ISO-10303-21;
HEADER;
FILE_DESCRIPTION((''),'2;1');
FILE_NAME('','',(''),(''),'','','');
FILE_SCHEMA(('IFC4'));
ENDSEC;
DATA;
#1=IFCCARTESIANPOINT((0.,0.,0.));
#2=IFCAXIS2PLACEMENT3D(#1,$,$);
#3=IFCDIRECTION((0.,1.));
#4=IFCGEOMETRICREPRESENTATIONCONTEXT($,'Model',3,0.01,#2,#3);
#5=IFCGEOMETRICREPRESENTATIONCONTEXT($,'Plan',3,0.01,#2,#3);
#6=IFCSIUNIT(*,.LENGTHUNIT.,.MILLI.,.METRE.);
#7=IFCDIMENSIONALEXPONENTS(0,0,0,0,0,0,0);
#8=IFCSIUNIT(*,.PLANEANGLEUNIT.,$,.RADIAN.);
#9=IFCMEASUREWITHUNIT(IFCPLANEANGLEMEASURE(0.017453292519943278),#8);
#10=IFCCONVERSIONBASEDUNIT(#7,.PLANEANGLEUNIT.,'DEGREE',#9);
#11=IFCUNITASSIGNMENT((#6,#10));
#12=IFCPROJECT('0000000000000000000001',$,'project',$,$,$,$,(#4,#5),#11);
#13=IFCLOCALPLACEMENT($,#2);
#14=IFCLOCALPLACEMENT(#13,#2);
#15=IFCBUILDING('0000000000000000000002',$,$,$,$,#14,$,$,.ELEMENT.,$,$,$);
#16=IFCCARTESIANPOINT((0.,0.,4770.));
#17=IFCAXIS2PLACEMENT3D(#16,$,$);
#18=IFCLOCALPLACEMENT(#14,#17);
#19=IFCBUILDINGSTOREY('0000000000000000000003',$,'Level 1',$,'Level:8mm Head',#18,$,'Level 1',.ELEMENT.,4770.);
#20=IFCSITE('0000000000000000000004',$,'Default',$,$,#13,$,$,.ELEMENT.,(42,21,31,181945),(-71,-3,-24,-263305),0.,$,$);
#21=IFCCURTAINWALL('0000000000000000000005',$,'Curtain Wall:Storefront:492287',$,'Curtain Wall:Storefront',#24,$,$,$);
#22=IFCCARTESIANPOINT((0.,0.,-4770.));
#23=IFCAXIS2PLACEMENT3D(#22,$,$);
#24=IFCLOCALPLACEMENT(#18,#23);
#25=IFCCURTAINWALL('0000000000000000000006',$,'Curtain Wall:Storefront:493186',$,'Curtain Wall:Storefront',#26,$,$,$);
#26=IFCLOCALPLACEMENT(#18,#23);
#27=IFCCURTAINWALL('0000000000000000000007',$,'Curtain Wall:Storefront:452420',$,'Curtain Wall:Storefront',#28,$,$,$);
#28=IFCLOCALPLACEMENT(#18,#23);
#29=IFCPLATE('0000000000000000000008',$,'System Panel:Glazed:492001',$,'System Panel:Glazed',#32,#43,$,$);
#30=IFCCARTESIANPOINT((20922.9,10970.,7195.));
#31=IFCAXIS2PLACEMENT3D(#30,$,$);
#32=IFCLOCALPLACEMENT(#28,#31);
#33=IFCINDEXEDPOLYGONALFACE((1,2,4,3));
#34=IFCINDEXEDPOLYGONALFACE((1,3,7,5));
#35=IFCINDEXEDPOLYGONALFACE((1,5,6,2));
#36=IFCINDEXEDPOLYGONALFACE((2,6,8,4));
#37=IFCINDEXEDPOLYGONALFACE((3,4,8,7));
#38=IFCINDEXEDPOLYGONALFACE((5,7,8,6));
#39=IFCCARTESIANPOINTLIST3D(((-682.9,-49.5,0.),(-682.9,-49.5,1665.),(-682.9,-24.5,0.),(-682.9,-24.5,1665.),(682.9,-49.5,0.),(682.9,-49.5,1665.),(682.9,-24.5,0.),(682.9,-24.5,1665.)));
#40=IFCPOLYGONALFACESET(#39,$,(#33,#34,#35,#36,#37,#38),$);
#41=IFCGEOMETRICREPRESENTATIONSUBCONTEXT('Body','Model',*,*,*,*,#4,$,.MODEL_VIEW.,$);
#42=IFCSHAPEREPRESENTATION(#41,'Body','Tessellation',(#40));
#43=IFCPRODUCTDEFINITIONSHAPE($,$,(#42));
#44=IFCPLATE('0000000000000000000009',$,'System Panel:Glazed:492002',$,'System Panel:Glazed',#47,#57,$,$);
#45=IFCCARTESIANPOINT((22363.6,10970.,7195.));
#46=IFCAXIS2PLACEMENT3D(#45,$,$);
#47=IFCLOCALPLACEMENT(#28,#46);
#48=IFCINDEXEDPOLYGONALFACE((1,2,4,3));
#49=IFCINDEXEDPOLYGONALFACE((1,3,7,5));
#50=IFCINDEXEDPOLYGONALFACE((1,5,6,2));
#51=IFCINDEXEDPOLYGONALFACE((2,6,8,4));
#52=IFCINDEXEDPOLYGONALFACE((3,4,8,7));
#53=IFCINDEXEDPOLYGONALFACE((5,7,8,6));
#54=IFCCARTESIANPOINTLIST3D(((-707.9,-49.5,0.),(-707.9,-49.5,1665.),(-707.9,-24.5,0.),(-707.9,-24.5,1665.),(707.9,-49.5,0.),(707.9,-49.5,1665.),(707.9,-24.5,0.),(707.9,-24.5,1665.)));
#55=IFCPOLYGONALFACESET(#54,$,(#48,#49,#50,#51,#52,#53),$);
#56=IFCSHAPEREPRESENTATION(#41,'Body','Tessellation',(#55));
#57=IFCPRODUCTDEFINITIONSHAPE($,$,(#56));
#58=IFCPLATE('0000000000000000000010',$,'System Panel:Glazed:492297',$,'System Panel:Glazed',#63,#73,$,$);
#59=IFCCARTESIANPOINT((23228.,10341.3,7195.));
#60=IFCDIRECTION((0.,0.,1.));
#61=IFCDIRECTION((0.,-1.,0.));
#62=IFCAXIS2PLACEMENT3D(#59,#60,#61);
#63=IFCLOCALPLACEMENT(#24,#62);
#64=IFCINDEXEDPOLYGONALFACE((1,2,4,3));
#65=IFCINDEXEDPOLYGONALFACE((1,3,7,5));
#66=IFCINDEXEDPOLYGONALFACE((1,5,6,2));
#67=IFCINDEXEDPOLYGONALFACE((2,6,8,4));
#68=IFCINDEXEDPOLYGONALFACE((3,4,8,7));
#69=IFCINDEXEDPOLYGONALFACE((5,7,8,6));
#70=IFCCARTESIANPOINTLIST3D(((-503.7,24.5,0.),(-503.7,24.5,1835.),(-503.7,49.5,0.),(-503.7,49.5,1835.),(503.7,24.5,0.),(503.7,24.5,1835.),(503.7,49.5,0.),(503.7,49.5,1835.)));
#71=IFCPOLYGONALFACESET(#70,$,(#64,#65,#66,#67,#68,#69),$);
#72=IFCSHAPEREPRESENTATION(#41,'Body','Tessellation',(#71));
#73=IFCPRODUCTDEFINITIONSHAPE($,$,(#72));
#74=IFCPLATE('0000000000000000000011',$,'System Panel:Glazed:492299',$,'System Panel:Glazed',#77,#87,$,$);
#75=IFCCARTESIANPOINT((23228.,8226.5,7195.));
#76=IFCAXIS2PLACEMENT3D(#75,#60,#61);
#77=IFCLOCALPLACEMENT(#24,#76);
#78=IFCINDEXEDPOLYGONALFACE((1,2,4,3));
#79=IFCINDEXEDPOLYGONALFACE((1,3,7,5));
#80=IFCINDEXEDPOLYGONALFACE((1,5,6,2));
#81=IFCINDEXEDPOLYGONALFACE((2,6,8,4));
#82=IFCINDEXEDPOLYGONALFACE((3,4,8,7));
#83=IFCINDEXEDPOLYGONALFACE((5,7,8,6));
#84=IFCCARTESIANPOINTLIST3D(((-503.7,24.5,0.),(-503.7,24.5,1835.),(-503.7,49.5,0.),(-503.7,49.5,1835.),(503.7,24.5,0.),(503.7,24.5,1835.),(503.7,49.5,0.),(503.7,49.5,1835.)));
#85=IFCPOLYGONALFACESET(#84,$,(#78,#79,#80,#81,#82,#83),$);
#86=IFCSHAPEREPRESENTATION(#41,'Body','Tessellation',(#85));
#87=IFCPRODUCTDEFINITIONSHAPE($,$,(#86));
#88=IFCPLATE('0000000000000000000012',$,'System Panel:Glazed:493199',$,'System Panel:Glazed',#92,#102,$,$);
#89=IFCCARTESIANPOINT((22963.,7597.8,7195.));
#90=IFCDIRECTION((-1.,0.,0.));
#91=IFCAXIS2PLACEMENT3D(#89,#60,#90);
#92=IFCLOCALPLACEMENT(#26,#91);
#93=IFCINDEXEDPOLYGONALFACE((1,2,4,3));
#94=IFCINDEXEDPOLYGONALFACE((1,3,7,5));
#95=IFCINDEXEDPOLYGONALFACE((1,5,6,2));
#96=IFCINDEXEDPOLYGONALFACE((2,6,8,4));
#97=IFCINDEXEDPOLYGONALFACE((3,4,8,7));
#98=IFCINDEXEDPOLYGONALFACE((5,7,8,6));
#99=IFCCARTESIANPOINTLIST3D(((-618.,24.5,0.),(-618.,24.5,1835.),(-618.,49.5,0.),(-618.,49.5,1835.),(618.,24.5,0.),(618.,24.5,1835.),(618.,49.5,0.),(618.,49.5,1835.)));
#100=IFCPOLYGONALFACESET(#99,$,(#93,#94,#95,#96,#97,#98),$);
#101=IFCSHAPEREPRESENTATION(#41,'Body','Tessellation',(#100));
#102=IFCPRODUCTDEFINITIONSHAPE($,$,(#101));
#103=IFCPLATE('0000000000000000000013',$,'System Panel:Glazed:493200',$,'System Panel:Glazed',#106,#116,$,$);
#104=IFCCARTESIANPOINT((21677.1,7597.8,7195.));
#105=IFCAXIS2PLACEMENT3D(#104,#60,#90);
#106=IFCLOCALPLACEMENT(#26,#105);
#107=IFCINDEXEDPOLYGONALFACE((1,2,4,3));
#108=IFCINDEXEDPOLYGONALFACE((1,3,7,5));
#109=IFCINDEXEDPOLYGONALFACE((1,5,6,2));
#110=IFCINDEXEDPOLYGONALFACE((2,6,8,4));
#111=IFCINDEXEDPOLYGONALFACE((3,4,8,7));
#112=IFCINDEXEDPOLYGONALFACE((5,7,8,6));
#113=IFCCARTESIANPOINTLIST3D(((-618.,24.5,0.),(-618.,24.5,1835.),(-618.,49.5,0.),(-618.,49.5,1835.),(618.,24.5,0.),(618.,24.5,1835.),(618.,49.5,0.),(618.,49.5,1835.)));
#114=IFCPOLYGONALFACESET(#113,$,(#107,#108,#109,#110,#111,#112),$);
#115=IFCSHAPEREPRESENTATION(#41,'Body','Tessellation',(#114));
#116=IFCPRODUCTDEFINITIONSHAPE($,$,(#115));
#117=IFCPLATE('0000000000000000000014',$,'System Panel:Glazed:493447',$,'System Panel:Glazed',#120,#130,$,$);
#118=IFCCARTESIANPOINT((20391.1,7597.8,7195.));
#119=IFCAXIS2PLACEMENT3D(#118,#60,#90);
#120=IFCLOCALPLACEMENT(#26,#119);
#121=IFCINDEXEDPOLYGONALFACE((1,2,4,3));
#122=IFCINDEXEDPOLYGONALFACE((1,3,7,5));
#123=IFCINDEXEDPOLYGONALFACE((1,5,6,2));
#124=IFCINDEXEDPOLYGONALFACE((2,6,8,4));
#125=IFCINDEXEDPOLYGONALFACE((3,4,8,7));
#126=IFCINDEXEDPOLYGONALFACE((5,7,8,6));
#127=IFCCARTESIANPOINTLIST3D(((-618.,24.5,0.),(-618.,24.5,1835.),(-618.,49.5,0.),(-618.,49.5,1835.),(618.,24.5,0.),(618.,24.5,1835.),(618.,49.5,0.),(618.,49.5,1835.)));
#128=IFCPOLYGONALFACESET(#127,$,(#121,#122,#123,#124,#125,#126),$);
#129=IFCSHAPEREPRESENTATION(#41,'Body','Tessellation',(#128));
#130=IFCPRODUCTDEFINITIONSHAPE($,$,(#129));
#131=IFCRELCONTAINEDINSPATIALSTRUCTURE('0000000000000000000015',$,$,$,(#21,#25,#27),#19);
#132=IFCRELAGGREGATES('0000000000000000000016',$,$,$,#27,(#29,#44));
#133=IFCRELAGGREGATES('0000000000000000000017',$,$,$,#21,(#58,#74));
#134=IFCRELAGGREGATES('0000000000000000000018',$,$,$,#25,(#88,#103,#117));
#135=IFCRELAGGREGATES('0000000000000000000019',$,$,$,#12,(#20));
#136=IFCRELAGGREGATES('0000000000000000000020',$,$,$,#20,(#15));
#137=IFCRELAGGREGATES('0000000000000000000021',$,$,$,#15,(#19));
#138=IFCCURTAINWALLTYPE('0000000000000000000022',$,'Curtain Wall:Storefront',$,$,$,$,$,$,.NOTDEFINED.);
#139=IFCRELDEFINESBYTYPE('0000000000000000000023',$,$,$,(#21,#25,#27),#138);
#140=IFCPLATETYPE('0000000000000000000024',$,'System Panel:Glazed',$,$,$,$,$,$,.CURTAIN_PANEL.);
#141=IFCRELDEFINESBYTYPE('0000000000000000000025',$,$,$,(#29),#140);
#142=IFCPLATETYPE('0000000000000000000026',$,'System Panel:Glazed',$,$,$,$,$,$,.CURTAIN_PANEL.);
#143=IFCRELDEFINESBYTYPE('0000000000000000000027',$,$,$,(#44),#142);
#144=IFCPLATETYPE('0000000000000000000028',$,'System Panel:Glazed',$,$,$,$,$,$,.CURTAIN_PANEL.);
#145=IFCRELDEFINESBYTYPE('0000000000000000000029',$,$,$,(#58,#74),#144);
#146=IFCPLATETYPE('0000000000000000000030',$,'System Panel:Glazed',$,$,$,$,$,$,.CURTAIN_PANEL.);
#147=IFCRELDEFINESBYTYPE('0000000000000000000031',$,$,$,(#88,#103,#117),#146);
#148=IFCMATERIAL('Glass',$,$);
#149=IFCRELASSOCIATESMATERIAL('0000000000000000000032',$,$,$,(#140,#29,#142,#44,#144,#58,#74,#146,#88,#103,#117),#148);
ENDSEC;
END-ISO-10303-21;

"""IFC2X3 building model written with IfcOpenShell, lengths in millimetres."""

from ifc_helpers import new_model, entity, si_unit, converted_unit, direction, frame, frame_2d, origin, origin_2d_with_axis, place, context, subcontext, project, spatial, rectangle, extrude, source, transform, mapped, material, type_object, type_shapes, element, aggregate, save


model = new_model("IFC2X3")

# Units and contexts
model_context = context("Model", 3, precision=0.01, world=origin(), true_north=direction((0.0, 1.0)))
plan_context = context("Plan", 3, precision=0.01, world=origin(), true_north=direction((0.0, 1.0)))
body_context = subcontext(model_context, "Body", "Model", "MODEL_VIEW")
ifc_project = project(units=[si_unit("LENGTHUNIT", "METRE", prefix="MILLI"), converted_unit("PLANEANGLEUNIT", "DEGREE", entity("IfcPlaneAngleMeasure", 0.017453292519943278), si_unit("PLANEANGLEUNIT", "RADIAN"), dimensions=[0, 0, 0, 0, 0, 0, 0])], contexts=[model_context, plan_context])

# Site, building, storey
site_placement = place(None, origin())
site = spatial("IfcSite", under=ifc_project, at=site_placement, Name="Default", CompositionType="ELEMENT", RefLatitude=(42, 21, 31, 181945), RefLongitude=(-71, -3, -24, -263305), RefElevation=0.0)
building_placement = place(site_placement, origin())
building = spatial("IfcBuilding", under=site, at=building_placement, CompositionType="ELEMENT")
storey_placement = place(building_placement, frame((0.0, 0.0, 4770.0)))
storey = spatial("IfcBuildingStorey", under=building, at=storey_placement, Name="Level 1", ObjectType="Level:8mm Head", LongName="Level 1", CompositionType="ELEMENT", Elevation=4770.0)

# Curtain wall
curtain_wall_type = type_object("IfcCurtainWallType", Name="Curtain Wall:Storefront", PredefinedType="NOTDEFINED")
curtain_wall_1_placement = place(storey_placement, frame((0.0, 0.0, -4770.0)))
curtain_wall_1 = element("IfcCurtainWall", 1, at=curtain_wall_1_placement, inside=storey, type_object=curtain_wall_type, Name="Curtain Wall:Storefront:492287", ObjectType="Curtain Wall:Storefront")

# Curtain wall
curtain_wall_2_placement = place(storey_placement, frame((0.0, 0.0, -4770.0)))
curtain_wall_2 = element("IfcCurtainWall", 2, at=curtain_wall_2_placement, inside=storey, type_object=curtain_wall_type, Name="Curtain Wall:Storefront:493186", ObjectType="Curtain Wall:Storefront")

# Curtain wall
curtain_wall_3_placement = place(storey_placement, frame((0.0, 0.0, -4770.0)))
curtain_wall_3 = element("IfcCurtainWall", 3, at=curtain_wall_3_placement, inside=storey, type_object=curtain_wall_type, Name="Curtain Wall:Storefront:452420", ObjectType="Curtain Wall:Storefront")

# Plates
ifc_material_1 = material(Name="Glass")
plate_type_1 = type_object("IfcPlateType", Name="System Panel:Glazed", PredefinedType="CURTAIN_PANEL", material=ifc_material_1)
shared_shape_1 = source(origin(), body_context, "Body", "SweptSolid", [
    extrude(rectangle(XDim=25.0, YDim=1365.7, at=frame_2d((0.0, 0.0), x_axis=(1.0, 0.0))), frame((0.0, -37.0, 0.0), z_axis=(0.0, 0.0, 1.0), x_axis=(0.0, 1.0, 0.0)), (0.0, 0.0, 1.0), 1665.0),
])
type_shapes(plate_type_1, [shared_shape_1])
plate_1_placement = place(curtain_wall_3_placement, frame((20922.9, 10970.0, 7195.0)))
plate_1 = element("IfcPlate", 4, at=plate_1_placement, type_object=plate_type_1, material=ifc_material_1, Name="System Panel:Glazed:492001", ObjectType="System Panel:Glazed", context=body_context, shape_type="MappedRepresentation", body=[
    mapped(shared_shape_1, transform((0.0, 0.0, 0.0), scale=1.0)),
])
plate_type_2 = type_object("IfcPlateType", Name="System Panel:Glazed", PredefinedType="CURTAIN_PANEL", material=ifc_material_1)
shared_shape_2 = source(origin(), body_context, "Body", "SweptSolid", [
    extrude(rectangle(XDim=25.0, YDim=1415.7, at=frame_2d((0.0, 0.0), x_axis=(1.0, 0.0))), frame((0.0, -37.0, 0.0), z_axis=(0.0, 0.0, 1.0), x_axis=(0.0, 1.0, 0.0)), (0.0, 0.0, 1.0), 1665.0),
])
type_shapes(plate_type_2, [shared_shape_2])
plate_2_placement = place(curtain_wall_3_placement, frame((22363.6, 10970.0, 7195.0)))
plate_2 = element("IfcPlate", 5, at=plate_2_placement, type_object=plate_type_2, material=ifc_material_1, Name="System Panel:Glazed:492002", ObjectType="System Panel:Glazed", context=body_context, shape_type="MappedRepresentation", body=[
    mapped(shared_shape_2, transform((0.0, 0.0, 0.0), scale=1.0)),
])
aggregate(curtain_wall_3, [plate_1, plate_2])
plate_type_3 = type_object("IfcPlateType", Name="System Panel:Glazed", PredefinedType="CURTAIN_PANEL", material=ifc_material_1)
shared_shape_3 = source(origin(), body_context, "Body", "SweptSolid", [
    extrude(rectangle(XDim=25.0, YDim=1007.4, at=origin_2d_with_axis()), frame((0.0, 37.0, 0.0), z_axis=(0.0, 0.0, 1.0), x_axis=(0.0, 1.0, 0.0)), (0.0, 0.0, 1.0), 1835.0),
])
type_shapes(plate_type_3, [shared_shape_3])
plate_3_placement = place(curtain_wall_1_placement, frame((23228.0, 10341.3, 7195.0), z_axis=(0.0, 0.0, 1.0), x_axis=(0.0, -1.0, 0.0)))
plate_3 = element("IfcPlate", 6, at=plate_3_placement, type_object=plate_type_3, material=ifc_material_1, Name="System Panel:Glazed:492297", ObjectType="System Panel:Glazed", context=body_context, shape_type="MappedRepresentation", body=[
    mapped(shared_shape_3, transform((0.0, 0.0, 0.0), scale=1.0)),
])
plate_4_placement = place(curtain_wall_1_placement, frame((23228.0, 8226.5, 7195.0), z_axis=(0.0, 0.0, 1.0), x_axis=(0.0, -1.0, 0.0)))
plate_4 = element("IfcPlate", 7, at=plate_4_placement, type_object=plate_type_3, material=ifc_material_1, Name="System Panel:Glazed:492299", ObjectType="System Panel:Glazed", context=body_context, shape_type="MappedRepresentation", body=[
    mapped(shared_shape_3, transform((0.0, 0.0, 0.0), scale=1.0)),
])
aggregate(curtain_wall_1, [plate_3, plate_4])
plate_type_4 = type_object("IfcPlateType", Name="System Panel:Glazed", PredefinedType="CURTAIN_PANEL", material=ifc_material_1)
shared_shape_4 = source(origin(), body_context, "Body", "SweptSolid", [
    extrude(rectangle(XDim=25.0, YDim=1236.0, at=origin_2d_with_axis()), frame((0.0, 37.0, 0.0), z_axis=(0.0, 0.0, 1.0), x_axis=(0.0, 1.0, 0.0)), (0.0, 0.0, 1.0), 1835.0),
])
type_shapes(plate_type_4, [shared_shape_4])
plate_5_placement = place(curtain_wall_2_placement, frame((22963.0, 7597.8, 7195.0), z_axis=(0.0, 0.0, 1.0), x_axis=(-1.0, 0.0, 0.0)))
plate_5 = element("IfcPlate", 8, at=plate_5_placement, type_object=plate_type_4, material=ifc_material_1, Name="System Panel:Glazed:493199", ObjectType="System Panel:Glazed", context=body_context, shape_type="MappedRepresentation", body=[
    mapped(shared_shape_4, transform((0.0, 0.0, 0.0), scale=1.0)),
])
plate_6_placement = place(curtain_wall_2_placement, frame((21677.1, 7597.8, 7195.0), z_axis=(0.0, 0.0, 1.0), x_axis=(-1.0, 0.0, 0.0)))
plate_6 = element("IfcPlate", 9, at=plate_6_placement, type_object=plate_type_4, material=ifc_material_1, Name="System Panel:Glazed:493200", ObjectType="System Panel:Glazed", context=body_context, shape_type="MappedRepresentation", body=[
    mapped(shared_shape_4, transform((0.0, 0.0, 0.0), scale=1.0)),
])
plate_7_placement = place(curtain_wall_2_placement, frame((20391.1, 7597.8, 7195.0), z_axis=(0.0, 0.0, 1.0), x_axis=(-1.0, 0.0, 0.0)))
plate_7 = element("IfcPlate", 10, at=plate_7_placement, type_object=plate_type_4, material=ifc_material_1, Name="System Panel:Glazed:493447", ObjectType="System Panel:Glazed", context=body_context, shape_type="MappedRepresentation", body=[
    mapped(shared_shape_4, transform((0.0, 0.0, 0.0), scale=1.0)),
])
aggregate(curtain_wall_2, [plate_5, plate_6, plate_7])

save(model, "model.ifc")
